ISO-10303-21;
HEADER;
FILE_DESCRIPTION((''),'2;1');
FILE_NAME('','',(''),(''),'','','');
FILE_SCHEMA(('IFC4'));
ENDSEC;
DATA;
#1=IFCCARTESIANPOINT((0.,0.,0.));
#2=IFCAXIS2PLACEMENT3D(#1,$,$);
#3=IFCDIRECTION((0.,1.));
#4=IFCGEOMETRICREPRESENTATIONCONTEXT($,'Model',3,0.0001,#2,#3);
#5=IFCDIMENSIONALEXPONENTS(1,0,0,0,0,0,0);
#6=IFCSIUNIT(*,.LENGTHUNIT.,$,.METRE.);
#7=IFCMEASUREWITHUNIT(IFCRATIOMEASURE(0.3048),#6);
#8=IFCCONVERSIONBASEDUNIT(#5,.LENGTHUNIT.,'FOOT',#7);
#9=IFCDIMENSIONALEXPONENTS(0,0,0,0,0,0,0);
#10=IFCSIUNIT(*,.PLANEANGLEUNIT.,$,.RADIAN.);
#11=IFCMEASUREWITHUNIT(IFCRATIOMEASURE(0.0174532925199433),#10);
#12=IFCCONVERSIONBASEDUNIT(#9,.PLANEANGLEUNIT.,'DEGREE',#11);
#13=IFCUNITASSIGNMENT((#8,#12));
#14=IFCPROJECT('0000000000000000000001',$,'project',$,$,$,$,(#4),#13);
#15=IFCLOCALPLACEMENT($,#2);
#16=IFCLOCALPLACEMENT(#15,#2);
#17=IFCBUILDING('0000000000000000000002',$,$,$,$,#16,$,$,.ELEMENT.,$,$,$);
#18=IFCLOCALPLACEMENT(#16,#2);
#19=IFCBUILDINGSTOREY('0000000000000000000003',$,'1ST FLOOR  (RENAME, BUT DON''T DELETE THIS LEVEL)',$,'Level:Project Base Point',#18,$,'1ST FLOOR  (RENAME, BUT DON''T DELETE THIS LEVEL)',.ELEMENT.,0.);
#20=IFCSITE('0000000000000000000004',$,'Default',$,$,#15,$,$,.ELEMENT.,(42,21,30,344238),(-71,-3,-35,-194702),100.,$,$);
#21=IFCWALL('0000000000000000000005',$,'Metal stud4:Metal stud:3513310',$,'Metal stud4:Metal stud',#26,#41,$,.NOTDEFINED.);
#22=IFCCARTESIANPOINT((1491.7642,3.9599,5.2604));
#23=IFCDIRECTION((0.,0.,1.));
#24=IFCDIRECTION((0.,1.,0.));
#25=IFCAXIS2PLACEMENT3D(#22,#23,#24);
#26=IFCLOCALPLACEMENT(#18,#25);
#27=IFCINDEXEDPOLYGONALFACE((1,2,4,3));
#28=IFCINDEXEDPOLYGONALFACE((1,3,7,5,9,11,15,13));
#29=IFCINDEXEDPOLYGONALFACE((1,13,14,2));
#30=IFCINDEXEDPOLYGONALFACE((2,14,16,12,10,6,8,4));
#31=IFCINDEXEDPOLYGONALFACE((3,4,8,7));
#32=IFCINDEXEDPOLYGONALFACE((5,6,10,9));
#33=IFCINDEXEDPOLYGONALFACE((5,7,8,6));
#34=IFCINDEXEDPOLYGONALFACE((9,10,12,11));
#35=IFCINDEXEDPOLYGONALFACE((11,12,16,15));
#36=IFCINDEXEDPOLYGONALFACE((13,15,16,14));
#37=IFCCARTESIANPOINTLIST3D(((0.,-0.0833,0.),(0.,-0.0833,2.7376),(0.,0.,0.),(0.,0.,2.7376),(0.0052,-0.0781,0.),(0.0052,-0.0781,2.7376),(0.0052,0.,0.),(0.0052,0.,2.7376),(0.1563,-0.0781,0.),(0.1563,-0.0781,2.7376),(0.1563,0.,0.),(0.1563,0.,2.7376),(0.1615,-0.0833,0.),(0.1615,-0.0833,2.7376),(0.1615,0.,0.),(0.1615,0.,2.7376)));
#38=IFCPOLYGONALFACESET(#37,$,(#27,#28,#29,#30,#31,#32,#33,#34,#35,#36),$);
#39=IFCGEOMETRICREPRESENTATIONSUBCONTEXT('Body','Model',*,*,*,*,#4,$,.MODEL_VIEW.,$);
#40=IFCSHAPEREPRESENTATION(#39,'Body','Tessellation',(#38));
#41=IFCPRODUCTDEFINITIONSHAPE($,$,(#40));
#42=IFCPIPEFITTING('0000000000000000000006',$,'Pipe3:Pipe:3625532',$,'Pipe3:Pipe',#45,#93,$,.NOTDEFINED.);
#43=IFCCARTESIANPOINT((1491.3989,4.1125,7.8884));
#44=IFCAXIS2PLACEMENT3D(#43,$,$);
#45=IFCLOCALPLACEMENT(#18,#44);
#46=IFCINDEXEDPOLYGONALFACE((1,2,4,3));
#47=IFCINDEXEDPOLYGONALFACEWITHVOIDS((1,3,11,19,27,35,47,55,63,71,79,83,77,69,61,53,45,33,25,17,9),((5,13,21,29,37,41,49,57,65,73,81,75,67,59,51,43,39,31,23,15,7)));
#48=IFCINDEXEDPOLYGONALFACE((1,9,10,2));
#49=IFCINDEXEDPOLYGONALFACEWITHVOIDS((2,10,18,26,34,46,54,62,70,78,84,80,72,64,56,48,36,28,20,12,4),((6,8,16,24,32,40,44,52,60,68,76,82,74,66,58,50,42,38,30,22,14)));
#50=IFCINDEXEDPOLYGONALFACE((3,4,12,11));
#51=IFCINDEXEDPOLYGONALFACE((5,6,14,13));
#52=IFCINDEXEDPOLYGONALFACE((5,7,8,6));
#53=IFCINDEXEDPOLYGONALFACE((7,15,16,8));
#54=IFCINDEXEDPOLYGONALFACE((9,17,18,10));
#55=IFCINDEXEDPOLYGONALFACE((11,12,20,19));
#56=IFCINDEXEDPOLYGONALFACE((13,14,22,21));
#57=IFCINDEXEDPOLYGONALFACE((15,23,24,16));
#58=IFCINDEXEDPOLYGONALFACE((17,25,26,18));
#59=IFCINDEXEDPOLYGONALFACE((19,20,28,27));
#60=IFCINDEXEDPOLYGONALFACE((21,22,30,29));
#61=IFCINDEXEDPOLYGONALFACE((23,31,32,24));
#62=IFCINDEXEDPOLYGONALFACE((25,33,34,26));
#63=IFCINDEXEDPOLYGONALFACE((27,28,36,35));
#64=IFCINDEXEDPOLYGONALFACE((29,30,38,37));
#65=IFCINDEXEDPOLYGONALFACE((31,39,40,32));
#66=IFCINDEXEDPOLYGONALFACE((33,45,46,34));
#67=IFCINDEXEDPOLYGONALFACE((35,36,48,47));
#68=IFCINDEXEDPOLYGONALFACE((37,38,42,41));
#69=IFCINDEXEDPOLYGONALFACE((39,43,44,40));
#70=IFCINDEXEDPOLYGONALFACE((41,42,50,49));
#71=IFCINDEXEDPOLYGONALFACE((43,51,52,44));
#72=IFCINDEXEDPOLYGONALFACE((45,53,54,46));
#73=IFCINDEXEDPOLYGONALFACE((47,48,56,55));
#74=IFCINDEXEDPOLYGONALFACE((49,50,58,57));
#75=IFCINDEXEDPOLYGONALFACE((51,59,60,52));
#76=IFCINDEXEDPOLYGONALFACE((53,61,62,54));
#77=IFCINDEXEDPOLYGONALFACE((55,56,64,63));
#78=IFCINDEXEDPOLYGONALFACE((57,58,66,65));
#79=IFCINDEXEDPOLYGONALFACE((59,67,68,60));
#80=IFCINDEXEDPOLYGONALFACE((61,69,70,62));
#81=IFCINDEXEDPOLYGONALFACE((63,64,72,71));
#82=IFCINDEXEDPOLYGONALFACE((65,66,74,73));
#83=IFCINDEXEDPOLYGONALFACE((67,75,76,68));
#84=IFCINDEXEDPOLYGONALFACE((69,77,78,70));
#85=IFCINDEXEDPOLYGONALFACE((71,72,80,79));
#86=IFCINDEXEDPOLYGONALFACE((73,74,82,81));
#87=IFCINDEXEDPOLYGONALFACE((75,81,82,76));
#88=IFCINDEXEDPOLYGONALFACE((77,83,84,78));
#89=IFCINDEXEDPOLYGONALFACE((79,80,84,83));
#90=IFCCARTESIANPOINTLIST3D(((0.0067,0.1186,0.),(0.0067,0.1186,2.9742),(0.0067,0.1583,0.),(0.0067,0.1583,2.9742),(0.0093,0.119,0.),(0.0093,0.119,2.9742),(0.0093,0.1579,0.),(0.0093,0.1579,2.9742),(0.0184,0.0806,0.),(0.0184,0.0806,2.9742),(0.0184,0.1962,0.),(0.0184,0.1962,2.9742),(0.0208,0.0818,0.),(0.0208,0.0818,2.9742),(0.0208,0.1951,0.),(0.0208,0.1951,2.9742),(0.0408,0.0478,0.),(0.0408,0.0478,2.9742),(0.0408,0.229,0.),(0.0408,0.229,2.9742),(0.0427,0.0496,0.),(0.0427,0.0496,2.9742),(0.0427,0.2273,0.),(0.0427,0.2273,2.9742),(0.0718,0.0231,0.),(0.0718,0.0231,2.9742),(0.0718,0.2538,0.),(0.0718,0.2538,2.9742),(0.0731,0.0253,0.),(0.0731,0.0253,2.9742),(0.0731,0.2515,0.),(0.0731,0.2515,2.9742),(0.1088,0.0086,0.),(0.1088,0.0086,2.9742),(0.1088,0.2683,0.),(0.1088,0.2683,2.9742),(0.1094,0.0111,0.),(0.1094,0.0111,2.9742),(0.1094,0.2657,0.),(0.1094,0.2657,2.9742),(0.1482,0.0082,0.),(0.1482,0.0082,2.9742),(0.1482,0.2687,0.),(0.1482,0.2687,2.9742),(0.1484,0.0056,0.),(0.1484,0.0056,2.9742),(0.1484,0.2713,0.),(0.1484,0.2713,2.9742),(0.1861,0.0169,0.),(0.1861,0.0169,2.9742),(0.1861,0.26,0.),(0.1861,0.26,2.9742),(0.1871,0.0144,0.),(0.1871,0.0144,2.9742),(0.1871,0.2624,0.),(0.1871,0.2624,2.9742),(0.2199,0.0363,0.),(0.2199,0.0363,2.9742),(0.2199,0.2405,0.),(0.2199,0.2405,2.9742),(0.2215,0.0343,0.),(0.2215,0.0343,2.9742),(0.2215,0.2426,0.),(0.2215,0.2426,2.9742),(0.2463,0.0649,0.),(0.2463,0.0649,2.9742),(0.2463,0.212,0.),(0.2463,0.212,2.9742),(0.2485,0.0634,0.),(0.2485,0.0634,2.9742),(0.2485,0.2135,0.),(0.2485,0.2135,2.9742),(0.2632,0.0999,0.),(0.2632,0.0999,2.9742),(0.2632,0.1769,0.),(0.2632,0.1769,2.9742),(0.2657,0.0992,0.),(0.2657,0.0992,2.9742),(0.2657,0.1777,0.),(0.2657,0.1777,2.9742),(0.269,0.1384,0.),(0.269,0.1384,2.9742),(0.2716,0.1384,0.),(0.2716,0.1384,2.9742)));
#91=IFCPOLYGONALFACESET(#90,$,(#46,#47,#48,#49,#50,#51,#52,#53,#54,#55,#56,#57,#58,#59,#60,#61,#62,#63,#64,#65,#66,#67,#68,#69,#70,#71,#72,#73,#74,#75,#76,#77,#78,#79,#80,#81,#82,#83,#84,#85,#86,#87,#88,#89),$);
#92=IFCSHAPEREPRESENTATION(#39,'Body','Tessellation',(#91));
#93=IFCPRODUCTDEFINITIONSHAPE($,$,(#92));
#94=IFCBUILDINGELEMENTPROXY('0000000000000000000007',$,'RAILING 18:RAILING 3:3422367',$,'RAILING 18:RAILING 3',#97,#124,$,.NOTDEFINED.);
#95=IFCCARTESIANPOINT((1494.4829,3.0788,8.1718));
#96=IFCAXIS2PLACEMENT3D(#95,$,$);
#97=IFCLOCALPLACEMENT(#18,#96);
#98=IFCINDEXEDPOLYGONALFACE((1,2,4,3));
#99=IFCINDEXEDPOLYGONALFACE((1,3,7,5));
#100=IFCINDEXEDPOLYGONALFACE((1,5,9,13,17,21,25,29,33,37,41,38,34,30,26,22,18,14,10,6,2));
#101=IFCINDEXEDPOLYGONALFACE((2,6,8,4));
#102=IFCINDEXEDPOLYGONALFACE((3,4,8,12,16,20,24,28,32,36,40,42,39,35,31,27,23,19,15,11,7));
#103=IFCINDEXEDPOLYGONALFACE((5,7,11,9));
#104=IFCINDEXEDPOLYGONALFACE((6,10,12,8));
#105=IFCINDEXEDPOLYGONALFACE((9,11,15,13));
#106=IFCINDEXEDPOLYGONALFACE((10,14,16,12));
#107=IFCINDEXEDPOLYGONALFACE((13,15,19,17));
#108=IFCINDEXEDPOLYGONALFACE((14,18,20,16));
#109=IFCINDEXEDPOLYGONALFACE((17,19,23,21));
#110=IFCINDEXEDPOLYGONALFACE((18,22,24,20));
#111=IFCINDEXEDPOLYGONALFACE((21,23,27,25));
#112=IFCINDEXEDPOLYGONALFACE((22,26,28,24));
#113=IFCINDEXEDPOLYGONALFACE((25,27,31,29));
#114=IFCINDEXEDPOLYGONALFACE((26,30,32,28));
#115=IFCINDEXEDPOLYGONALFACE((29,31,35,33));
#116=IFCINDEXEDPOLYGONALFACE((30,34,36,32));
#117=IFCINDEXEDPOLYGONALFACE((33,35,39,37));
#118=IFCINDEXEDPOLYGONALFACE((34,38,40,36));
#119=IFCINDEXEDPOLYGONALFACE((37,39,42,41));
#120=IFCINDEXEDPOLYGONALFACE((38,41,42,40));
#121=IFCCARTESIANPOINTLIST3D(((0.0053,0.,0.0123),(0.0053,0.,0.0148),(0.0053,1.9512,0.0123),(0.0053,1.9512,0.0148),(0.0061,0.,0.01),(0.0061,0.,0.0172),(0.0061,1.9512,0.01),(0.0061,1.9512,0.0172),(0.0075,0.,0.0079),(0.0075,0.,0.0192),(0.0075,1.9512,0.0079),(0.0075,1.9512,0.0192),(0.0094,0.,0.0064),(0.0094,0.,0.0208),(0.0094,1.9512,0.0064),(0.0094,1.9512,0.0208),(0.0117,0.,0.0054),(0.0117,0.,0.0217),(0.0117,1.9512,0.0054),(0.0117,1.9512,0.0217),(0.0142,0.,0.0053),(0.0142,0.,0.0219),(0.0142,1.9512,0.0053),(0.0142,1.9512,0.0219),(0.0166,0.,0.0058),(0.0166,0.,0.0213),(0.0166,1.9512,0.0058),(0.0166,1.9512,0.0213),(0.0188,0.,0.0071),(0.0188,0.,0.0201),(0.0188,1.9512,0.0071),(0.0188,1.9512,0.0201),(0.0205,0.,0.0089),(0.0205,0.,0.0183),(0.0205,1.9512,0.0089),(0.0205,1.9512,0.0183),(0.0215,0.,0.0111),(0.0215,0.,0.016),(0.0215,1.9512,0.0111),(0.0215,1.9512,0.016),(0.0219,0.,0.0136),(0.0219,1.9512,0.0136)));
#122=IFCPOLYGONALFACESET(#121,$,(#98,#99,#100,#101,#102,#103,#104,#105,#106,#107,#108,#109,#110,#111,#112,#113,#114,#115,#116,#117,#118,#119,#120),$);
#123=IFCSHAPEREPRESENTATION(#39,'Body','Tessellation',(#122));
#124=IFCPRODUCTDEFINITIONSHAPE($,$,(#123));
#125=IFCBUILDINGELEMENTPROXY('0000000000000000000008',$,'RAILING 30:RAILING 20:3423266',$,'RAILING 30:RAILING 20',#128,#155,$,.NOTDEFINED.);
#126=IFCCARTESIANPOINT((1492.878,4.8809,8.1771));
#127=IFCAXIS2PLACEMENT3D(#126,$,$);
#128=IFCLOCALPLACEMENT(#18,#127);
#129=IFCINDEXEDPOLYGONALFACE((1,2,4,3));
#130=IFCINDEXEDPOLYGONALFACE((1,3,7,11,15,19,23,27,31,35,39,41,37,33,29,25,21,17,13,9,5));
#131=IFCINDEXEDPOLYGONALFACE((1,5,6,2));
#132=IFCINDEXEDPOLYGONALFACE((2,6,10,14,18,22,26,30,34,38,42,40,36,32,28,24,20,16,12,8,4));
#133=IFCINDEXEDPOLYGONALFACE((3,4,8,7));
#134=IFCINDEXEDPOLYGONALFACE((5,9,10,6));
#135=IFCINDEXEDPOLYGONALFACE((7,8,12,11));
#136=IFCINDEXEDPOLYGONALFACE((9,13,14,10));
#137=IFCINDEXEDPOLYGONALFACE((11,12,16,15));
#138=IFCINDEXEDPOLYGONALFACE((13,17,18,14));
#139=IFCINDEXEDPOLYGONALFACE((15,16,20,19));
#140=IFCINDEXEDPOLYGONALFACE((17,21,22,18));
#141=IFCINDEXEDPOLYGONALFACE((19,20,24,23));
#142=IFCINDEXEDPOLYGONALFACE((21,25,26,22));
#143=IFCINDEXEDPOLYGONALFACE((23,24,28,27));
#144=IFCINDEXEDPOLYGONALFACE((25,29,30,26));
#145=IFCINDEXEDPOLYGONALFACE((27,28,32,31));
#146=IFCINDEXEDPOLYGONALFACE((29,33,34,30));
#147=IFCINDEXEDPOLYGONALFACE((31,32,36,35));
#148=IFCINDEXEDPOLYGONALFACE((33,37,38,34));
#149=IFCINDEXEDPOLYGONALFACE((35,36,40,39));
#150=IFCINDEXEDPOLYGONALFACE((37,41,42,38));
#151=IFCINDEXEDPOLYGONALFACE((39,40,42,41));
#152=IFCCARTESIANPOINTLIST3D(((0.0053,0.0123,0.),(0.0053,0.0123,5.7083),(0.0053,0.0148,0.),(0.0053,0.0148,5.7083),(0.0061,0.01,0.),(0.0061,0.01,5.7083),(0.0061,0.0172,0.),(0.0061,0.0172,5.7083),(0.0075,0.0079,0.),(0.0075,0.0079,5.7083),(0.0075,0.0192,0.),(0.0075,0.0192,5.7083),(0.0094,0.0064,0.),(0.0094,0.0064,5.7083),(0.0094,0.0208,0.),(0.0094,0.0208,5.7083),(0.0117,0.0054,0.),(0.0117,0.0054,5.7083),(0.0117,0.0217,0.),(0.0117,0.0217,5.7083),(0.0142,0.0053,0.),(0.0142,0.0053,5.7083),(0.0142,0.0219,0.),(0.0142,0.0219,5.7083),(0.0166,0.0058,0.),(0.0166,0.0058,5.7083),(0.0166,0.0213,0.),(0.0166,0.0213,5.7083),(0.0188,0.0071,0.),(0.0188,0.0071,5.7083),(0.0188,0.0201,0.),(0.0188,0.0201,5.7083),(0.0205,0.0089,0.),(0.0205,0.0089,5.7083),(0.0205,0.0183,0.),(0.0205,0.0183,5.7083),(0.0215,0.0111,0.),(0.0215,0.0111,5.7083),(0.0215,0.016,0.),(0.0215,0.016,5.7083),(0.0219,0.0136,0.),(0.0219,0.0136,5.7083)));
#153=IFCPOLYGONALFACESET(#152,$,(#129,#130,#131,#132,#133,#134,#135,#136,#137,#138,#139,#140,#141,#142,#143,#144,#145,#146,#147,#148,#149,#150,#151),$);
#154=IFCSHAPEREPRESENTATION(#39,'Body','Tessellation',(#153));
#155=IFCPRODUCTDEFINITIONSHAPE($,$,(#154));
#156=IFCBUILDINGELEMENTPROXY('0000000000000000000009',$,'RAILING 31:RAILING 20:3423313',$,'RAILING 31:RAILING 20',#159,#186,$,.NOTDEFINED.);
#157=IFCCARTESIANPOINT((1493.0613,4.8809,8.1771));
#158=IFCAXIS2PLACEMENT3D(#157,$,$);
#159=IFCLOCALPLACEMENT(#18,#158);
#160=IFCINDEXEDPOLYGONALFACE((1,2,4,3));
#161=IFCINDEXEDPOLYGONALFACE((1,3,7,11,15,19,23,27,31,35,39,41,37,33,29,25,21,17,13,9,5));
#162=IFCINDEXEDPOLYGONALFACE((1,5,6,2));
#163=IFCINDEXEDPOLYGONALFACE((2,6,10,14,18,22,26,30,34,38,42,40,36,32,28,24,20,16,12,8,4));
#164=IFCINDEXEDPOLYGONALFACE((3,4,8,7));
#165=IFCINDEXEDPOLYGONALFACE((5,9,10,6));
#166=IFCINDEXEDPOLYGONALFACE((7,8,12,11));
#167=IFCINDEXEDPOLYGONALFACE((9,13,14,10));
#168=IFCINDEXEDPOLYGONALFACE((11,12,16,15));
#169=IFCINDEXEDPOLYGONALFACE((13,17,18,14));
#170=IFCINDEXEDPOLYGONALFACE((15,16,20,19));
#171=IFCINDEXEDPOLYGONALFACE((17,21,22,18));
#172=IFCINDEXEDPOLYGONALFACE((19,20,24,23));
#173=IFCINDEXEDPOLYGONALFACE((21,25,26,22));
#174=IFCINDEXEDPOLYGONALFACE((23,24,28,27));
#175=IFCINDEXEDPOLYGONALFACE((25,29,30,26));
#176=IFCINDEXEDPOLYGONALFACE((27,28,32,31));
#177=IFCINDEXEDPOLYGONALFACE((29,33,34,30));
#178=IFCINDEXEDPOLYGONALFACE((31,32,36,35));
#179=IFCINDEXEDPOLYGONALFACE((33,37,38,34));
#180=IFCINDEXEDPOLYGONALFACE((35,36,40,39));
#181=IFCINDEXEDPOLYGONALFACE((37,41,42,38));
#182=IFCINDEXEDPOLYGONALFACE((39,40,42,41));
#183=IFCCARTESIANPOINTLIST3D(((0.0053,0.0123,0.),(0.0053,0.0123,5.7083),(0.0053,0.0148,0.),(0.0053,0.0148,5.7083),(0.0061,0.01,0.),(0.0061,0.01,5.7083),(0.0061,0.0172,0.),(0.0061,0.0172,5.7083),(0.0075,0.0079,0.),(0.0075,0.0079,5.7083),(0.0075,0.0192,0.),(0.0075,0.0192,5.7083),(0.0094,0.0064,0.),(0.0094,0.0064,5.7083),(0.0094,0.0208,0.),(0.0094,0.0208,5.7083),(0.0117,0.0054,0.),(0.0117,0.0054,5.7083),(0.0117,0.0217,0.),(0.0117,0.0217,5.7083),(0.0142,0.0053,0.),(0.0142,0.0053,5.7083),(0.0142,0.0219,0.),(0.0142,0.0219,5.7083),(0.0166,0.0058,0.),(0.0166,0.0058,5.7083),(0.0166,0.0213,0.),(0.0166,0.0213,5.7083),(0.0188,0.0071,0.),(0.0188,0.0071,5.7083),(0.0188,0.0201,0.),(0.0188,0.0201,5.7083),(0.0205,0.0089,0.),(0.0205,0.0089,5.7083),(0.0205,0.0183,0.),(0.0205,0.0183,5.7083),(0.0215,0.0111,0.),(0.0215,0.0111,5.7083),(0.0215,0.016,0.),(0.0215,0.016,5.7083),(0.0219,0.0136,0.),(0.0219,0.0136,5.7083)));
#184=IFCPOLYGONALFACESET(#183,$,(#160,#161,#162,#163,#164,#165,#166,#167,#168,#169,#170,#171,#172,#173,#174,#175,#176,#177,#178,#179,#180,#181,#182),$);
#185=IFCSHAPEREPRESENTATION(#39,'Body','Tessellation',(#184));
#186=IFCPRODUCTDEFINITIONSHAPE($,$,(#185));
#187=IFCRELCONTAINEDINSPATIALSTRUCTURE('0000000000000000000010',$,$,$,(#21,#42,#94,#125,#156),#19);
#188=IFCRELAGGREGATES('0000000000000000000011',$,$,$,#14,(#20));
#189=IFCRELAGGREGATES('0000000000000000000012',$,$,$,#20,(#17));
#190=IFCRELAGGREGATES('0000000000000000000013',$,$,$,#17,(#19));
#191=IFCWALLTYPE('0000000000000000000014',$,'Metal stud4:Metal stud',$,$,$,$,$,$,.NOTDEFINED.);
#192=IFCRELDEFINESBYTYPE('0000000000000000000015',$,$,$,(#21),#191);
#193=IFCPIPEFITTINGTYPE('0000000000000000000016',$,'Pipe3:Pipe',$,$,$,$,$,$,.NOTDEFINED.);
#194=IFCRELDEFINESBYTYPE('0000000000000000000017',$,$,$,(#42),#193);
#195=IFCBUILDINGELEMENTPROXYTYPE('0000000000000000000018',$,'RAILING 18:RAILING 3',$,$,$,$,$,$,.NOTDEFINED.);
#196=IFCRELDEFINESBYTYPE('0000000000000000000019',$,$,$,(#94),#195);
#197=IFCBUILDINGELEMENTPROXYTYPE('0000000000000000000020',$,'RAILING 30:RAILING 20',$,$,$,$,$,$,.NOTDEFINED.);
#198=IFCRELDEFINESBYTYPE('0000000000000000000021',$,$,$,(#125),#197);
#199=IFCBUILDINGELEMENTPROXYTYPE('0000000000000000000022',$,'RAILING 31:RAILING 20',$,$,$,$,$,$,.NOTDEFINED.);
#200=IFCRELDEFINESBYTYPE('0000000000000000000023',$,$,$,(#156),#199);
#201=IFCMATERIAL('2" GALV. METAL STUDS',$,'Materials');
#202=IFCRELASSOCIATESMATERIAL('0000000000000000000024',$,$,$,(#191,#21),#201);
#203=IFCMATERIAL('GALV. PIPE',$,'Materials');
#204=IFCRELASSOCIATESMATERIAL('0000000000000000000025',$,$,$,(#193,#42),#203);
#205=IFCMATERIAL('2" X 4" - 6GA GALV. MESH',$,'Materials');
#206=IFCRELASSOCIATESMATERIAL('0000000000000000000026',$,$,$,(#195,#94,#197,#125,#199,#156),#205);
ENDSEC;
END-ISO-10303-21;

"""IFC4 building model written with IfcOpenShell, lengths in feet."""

from ifc_helpers import new_model, entity, si_unit, converted_unit, direction, frame, frame_2d, origin, origin_2d_with_axis, place, context, subcontext, project, spatial, polyline, circle, hollow_circle, outline, extrude, source, transform, mapped, material, type_object, type_shapes, element, save


model = new_model("IFC4")

# Units and contexts
model_context = context("Model", 3, precision=0.0001, world=origin(), true_north=direction((0.0, 1.0)))
body_context = subcontext(model_context, "Body", "Model", "MODEL_VIEW")
ifc_project = project(units=[converted_unit("LENGTHUNIT", "FOOT", entity("IfcRatioMeasure", 0.3048), si_unit("LENGTHUNIT", "METRE"), dimensions=[1, 0, 0, 0, 0, 0, 0]), converted_unit("PLANEANGLEUNIT", "DEGREE", entity("IfcRatioMeasure", 0.0174532925199433), si_unit("PLANEANGLEUNIT", "RADIAN"), dimensions=[0, 0, 0, 0, 0, 0, 0])], contexts=[model_context])

# Site, building, storey
site_placement = place(None, origin())
site = spatial("IfcSite", under=ifc_project, at=site_placement, Name="Default", CompositionType="ELEMENT", RefLatitude=(42, 21, 30, 344238), RefLongitude=(-71, -3, -35, -194702), RefElevation=100.0)
building_placement = place(site_placement, origin())
building = spatial("IfcBuilding", under=site, at=building_placement, CompositionType="ELEMENT")
storey_placement = place(building_placement, origin())
storey = spatial("IfcBuildingStorey", under=building, at=storey_placement, Name="1ST FLOOR  (RENAME, BUT DON'T DELETE THIS LEVEL)", ObjectType="Level:Project Base Point", LongName="1ST FLOOR  (RENAME, BUT DON'T DELETE THIS LEVEL)", CompositionType="ELEMENT", Elevation=0.0)

# Wall
ifc_material_1 = material(Name="2\" GALV. METAL STUDS", Category="Materials")
wall_type_1 = type_object("IfcWallType", Name="Metal stud4:Metal stud", PredefinedType="NOTDEFINED", material=ifc_material_1)
wall_1_placement = place(storey_placement, frame((1491.7642, 3.9599, 5.2604), z_axis=(0.0, 0.0, 1.0), x_axis=(0.0, 1.0, 0.0)))
element("IfcWall", 1, at=wall_1_placement, inside=storey, type_object=wall_type_1, material=ifc_material_1, Name="Metal stud4:Metal stud:3513310", ObjectType="Metal stud4:Metal stud", PredefinedType="NOTDEFINED", context=body_context, shape_type="SweptSolid", body=[
    extrude(outline(polyline([(-0.043, -0.0807), (0.0404, -0.0807), (0.0404, -0.0755), (-0.0378, -0.0755), (-0.0378, 0.0755), (0.0404, 0.0755), (0.0404, 0.0807), (-0.043, 0.0807), (-0.043, -0.0807)])), frame((0.0807, -0.0404, 0.0), z_axis=(0.0, 0.0, 1.0), x_axis=(0.0, 1.0, 0.0)), (0.0, 0.0, 1.0), 2.7376),
])

# Pipe fitting
ifc_material_2 = material(Name="GALV. PIPE", Category="Materials")
pipe_fitting_type_1 = type_object("IfcPipeFittingType", Name="Pipe3:Pipe", PredefinedType="NOTDEFINED", material=ifc_material_2)
shared_shape_1 = source(origin(), body_context, "Body", "SweptSolid", [
    extrude(hollow_circle(Radius=0.1332, WallThickness=0.0026, at=frame_2d((0.0, 0.0), x_axis=(1.0, 0.0))), frame((0.1384, 0.1384, 0.0)), (0.0, 0.0, 1.0), 2.9742),
])
type_shapes(pipe_fitting_type_1, [shared_shape_1])
pipe_fitting_1_placement = place(storey_placement, frame((1491.3989, 4.1125, 7.8884)))
element("IfcPipeFitting", 2, at=pipe_fitting_1_placement, inside=storey, type_object=pipe_fitting_type_1, material=ifc_material_2, Name="Pipe3:Pipe:3625532", ObjectType="Pipe3:Pipe", PredefinedType="NOTDEFINED", context=body_context, shape_type="MappedRepresentation", body=[
    mapped(shared_shape_1, transform((0.0, 0.0, 0.0), scale=1.0)),
])

# Building element proxies
ifc_material_3 = material(Name="2\" X 4\" - 6GA GALV. MESH", Category="Materials")
building_element_proxy_type_1 = type_object("IfcBuildingElementProxyType", Name="RAILING 18:RAILING 3", PredefinedType="NOTDEFINED", material=ifc_material_3)
shared_shape_2 = source(origin(), body_context, "Body", "SweptSolid", [
    extrude(circle(Radius=0.0083, at=origin_2d_with_axis()), frame((0.0136, 0.0, 0.0136), z_axis=(0.0, 1.0, 0.0), x_axis=(1.0, 0.0, 0.0)), (0.0, 0.0, 1.0), 1.9512),
])
type_shapes(building_element_proxy_type_1, [shared_shape_2])
proxy_1_placement = place(storey_placement, frame((1494.4829, 3.0788, 8.1718)))
element("IfcBuildingElementProxy", 3, at=proxy_1_placement, inside=storey, type_object=building_element_proxy_type_1, material=ifc_material_3, Name="RAILING 18:RAILING 3:3422367", ObjectType="RAILING 18:RAILING 3", PredefinedType="NOTDEFINED", context=body_context, shape_type="MappedRepresentation", body=[
    mapped(shared_shape_2, transform((0.0, 0.0, 0.0), scale=1.0)),
])
building_element_proxy_type_2 = type_object("IfcBuildingElementProxyType", Name="RAILING 30:RAILING 20", PredefinedType="NOTDEFINED", material=ifc_material_3)
shared_shape_3 = source(origin(), body_context, "Body", "SweptSolid", [
    extrude(circle(Radius=0.0083, at=origin_2d_with_axis()), frame((0.0136, 0.0136, 0.0)), (0.0, 0.0, 1.0), 5.7083),
])
type_shapes(building_element_proxy_type_2, [shared_shape_3])
proxy_2_placement = place(storey_placement, frame((1492.878, 4.8809, 8.1771)))
element("IfcBuildingElementProxy", 4, at=proxy_2_placement, inside=storey, type_object=building_element_proxy_type_2, material=ifc_material_3, Name="RAILING 30:RAILING 20:3423266", ObjectType="RAILING 30:RAILING 20", PredefinedType="NOTDEFINED", context=body_context, shape_type="MappedRepresentation", body=[
    mapped(shared_shape_3, transform((0.0, 0.0, 0.0), scale=1.0)),
])
building_element_proxy_type_3 = type_object("IfcBuildingElementProxyType", Name="RAILING 31:RAILING 20", PredefinedType="NOTDEFINED", material=ifc_material_3)
shared_shape_4 = source(origin(), body_context, "Body", "SweptSolid", [
    extrude(circle(Radius=0.0083, at=origin_2d_with_axis()), frame((0.0136, 0.0136, 0.0)), (0.0, 0.0, 1.0), 5.7083),
])
type_shapes(building_element_proxy_type_3, [shared_shape_4])
proxy_3_placement = place(storey_placement, frame((1493.0613, 4.8809, 8.1771)))
element("IfcBuildingElementProxy", 5, at=proxy_3_placement, inside=storey, type_object=building_element_proxy_type_3, material=ifc_material_3, Name="RAILING 31:RAILING 20:3423313", ObjectType="RAILING 31:RAILING 20", PredefinedType="NOTDEFINED", context=body_context, shape_type="MappedRepresentation", body=[
    mapped(shared_shape_4, transform((0.0, 0.0, 0.0), scale=1.0)),
])

save(model, "model.ifc")
